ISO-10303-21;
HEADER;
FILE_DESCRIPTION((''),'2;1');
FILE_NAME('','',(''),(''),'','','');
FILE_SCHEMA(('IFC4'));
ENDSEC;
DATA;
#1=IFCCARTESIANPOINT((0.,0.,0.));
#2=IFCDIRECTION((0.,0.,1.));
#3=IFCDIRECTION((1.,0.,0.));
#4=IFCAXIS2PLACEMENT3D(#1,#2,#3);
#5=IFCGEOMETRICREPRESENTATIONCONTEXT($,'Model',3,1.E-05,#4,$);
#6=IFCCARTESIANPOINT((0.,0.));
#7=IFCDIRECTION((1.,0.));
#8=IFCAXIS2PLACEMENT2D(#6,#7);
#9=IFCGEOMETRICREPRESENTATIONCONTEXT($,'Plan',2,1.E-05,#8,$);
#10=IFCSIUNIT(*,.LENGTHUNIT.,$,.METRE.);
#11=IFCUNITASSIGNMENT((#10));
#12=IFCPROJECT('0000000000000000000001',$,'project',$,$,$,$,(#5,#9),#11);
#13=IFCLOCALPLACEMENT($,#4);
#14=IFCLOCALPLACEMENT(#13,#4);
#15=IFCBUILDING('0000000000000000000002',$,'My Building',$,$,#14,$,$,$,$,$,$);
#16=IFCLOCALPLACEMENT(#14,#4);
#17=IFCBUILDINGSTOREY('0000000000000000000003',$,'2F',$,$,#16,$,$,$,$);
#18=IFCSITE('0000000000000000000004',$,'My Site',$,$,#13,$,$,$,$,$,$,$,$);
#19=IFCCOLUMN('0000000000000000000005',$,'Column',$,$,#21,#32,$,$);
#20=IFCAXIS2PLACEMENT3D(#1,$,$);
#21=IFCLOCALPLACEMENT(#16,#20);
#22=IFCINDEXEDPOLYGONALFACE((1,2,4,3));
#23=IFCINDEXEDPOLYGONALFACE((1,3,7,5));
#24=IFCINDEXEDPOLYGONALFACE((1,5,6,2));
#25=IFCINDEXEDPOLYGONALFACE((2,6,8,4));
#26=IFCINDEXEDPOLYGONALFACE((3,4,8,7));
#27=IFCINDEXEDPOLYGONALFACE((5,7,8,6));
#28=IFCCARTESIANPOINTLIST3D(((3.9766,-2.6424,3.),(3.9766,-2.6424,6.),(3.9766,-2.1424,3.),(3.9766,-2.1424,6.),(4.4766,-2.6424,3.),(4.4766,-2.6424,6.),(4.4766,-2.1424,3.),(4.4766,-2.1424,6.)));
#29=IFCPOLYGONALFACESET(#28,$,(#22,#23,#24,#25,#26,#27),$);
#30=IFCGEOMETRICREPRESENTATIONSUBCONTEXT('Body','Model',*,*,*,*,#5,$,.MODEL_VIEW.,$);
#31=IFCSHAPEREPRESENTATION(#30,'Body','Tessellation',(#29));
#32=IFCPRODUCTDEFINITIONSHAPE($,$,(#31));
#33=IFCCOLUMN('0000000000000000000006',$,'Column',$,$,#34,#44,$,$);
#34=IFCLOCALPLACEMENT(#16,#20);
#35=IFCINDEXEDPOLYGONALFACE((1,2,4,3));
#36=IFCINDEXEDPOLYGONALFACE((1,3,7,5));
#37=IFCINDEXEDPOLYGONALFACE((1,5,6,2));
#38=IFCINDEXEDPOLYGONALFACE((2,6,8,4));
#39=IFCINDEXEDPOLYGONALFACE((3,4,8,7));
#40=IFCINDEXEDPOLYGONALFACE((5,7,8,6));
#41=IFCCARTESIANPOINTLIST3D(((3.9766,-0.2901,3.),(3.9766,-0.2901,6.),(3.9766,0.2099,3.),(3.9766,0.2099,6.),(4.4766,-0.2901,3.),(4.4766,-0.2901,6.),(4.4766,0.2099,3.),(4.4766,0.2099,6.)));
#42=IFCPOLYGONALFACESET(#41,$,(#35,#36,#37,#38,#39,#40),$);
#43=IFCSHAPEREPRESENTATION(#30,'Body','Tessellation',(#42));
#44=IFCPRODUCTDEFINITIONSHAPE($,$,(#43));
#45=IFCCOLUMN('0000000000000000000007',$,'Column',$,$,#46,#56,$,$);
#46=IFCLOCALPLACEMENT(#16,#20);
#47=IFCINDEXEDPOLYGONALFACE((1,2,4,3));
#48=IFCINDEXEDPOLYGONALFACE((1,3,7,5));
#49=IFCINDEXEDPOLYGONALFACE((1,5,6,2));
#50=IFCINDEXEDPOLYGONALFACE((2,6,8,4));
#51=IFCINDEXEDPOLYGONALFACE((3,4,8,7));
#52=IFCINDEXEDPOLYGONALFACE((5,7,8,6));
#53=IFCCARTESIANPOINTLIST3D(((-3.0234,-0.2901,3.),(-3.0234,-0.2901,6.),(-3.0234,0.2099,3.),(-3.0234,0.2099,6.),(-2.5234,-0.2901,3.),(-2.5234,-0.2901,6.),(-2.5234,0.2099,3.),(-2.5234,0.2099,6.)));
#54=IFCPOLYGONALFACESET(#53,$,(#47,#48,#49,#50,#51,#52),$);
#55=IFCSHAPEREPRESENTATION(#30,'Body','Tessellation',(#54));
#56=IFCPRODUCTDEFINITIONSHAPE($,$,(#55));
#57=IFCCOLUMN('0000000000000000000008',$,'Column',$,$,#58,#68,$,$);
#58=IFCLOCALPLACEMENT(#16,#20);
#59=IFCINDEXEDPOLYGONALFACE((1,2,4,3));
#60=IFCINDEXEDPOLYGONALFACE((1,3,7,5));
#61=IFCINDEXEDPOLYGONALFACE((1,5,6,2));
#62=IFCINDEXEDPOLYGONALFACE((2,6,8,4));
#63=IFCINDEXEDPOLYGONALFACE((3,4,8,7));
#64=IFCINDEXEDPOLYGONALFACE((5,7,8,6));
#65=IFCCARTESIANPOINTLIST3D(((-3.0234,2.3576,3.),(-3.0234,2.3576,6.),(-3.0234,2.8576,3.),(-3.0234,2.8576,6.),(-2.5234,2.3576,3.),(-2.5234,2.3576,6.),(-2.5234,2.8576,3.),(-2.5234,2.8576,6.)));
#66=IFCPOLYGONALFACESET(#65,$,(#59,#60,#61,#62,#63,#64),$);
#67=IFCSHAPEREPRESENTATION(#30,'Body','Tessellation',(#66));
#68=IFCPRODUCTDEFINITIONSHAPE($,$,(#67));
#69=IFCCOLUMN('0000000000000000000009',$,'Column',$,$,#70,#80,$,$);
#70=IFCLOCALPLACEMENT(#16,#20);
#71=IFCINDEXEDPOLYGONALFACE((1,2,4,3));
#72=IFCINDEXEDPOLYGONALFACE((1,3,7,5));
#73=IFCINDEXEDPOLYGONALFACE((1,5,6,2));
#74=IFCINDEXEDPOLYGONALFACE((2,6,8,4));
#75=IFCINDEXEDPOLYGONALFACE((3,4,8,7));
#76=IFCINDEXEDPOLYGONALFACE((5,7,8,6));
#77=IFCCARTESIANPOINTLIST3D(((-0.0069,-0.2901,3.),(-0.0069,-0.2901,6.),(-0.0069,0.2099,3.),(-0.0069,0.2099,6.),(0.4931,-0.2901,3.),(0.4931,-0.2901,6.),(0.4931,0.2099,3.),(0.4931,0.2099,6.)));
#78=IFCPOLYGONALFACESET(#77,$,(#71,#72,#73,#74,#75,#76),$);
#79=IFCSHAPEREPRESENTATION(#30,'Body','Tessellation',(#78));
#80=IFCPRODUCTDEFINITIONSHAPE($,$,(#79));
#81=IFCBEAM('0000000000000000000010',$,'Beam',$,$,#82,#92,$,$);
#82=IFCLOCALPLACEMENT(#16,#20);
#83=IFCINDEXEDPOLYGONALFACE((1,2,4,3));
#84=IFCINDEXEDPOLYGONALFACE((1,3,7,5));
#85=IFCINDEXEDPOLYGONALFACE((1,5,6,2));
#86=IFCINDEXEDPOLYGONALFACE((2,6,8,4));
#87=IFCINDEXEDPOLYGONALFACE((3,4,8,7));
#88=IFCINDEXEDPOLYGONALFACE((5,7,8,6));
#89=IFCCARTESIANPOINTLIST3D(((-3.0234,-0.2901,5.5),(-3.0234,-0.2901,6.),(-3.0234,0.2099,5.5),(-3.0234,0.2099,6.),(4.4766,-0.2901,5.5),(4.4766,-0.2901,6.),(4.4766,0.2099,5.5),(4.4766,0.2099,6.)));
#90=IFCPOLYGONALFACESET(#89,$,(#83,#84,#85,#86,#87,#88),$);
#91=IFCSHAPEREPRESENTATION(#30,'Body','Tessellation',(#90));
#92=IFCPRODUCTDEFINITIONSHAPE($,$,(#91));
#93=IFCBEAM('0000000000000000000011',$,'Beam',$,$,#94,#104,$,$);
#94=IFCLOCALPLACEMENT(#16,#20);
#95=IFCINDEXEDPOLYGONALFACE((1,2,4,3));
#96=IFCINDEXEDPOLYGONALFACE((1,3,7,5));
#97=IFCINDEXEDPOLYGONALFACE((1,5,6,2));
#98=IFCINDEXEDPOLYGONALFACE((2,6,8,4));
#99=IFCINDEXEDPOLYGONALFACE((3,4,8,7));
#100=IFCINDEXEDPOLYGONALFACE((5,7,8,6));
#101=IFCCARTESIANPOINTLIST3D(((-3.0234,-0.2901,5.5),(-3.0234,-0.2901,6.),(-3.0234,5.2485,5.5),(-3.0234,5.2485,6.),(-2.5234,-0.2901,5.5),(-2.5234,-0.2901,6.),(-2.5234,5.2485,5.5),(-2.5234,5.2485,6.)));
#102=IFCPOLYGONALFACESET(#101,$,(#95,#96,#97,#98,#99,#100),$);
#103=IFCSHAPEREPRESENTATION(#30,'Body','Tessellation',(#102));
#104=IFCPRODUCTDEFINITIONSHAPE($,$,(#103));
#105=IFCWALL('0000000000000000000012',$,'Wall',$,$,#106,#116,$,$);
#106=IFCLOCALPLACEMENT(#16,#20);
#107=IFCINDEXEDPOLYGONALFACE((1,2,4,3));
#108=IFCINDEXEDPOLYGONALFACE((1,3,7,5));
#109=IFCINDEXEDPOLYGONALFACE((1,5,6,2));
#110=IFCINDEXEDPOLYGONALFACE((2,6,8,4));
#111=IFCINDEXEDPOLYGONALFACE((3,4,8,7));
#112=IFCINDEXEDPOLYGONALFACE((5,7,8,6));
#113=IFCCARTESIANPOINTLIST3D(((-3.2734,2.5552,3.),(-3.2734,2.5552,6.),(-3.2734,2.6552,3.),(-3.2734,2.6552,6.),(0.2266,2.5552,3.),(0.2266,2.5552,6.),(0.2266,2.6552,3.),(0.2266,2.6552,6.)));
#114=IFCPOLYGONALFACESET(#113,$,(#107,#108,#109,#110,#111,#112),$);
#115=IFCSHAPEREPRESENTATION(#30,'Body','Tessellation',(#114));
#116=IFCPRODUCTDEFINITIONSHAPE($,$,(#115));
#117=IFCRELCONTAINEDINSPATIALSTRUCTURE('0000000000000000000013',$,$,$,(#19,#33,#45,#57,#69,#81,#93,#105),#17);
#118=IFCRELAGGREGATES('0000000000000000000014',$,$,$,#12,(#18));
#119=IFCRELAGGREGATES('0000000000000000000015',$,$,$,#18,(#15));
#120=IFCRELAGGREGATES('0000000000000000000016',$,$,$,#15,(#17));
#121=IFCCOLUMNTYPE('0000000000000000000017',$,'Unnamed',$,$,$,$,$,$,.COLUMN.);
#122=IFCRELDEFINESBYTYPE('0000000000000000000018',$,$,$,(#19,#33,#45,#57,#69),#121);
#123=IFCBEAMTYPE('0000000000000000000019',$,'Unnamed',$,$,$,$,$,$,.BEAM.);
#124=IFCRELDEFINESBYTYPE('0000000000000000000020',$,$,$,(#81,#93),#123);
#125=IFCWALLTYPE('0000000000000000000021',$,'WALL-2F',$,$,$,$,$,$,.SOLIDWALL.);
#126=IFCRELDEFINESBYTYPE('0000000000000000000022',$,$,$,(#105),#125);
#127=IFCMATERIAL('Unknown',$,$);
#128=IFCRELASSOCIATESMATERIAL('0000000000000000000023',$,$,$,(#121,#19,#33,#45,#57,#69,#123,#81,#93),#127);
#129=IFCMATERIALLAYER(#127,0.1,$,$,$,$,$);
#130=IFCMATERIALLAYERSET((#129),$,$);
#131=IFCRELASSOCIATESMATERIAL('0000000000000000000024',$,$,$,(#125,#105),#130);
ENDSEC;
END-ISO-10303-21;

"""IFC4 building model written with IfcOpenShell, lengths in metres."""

from ifc_helpers import new_model, si_unit, frame, origin_with_axes, origin_2d_with_axis, place, context, subcontext, project, spatial, line, indexed_curve, rectangle, outline, extrude, material, layer, layer_set, layer_usage, material_profile, profile_set, profile_usage, type_object, element, save


model = new_model("IFC4")

# Units and contexts
model_context = context("Model", 3, precision=1e-05, world=origin_with_axes())
plan_context = context("Plan", 2, precision=1e-05, world=origin_2d_with_axis())
body_context_1 = subcontext(model_context, "Body", "Model", "MODEL_VIEW")
ifc_project = project(units=[si_unit("LENGTHUNIT", "METRE")], contexts=[model_context, plan_context])

# Site, building, storey
site_placement = place(None, origin_with_axes())
site = spatial("IfcSite", under=ifc_project, at=site_placement, Name="My Site")
building_placement = place(site_placement, origin_with_axes())
building = spatial("IfcBuilding", under=site, at=building_placement, Name="My Building")
storey_placement = place(building_placement, origin_with_axes())
storey = spatial("IfcBuildingStorey", under=building, at=storey_placement, Name="2F")

# Columns
ifc_material = material(Name="Unknown")
ifc_material_profile_1 = material_profile(ifc_material, rectangle(XDim=0.5, YDim=0.5))
ifc_profile_set_1 = profile_set([ifc_material_profile_1])
ifc_profile_usage_1 = profile_usage(ifc_profile_set_1, cardinal=7)
column_type = type_object("IfcColumnType", Name="Unnamed", PredefinedType="COLUMN", material=ifc_profile_set_1)
column_1_placement = place(storey_placement, frame((4.4766, -2.1424, 3.0), z_axis=(0.0, 0.0, 1.0), x_axis=(1.0, 0.0, 0.0)))
element("IfcColumn", 1, at=column_1_placement, inside=storey, type_object=column_type, material=ifc_profile_usage_1, Name="Column", context=body_context_1, shape_type="SweptSolid", body=[
    extrude(rectangle(XDim=0.5, YDim=0.5), frame((-0.25, -0.25, 0.0), z_axis=(0.0, 0.0, 1.0), x_axis=(1.0, 0.0, 0.0)), (0.0, 0.0, 1.0), 3.0),
])
ifc_profile_usage_2 = profile_usage(ifc_profile_set_1, cardinal=7)
column_2_placement = place(storey_placement, frame((4.4766, 0.2099, 3.0), z_axis=(0.0, 0.0, 1.0), x_axis=(1.0, 0.0, 0.0)))
element("IfcColumn", 2, at=column_2_placement, inside=storey, type_object=column_type, material=ifc_profile_usage_2, Name="Column", context=body_context_1, shape_type="SweptSolid", body=[
    extrude(rectangle(XDim=0.5, YDim=0.5), frame((-0.25, -0.25, 0.0), z_axis=(0.0, 0.0, 1.0), x_axis=(1.0, 0.0, 0.0)), (0.0, 0.0, 1.0), 3.0),
])
ifc_profile_usage_3 = profile_usage(ifc_profile_set_1, cardinal=7)
column_3_placement = place(storey_placement, frame((-2.5234, 0.2099, 3.0), z_axis=(0.0, 0.0, 1.0), x_axis=(1.0, 0.0, 0.0)))
element("IfcColumn", 3, at=column_3_placement, inside=storey, type_object=column_type, material=ifc_profile_usage_3, Name="Column", context=body_context_1, shape_type="SweptSolid", body=[
    extrude(rectangle(XDim=0.5, YDim=0.5), frame((-0.25, -0.25, 0.0), z_axis=(0.0, 0.0, 1.0), x_axis=(1.0, 0.0, 0.0)), (0.0, 0.0, 1.0), 3.0),
])
ifc_profile_usage_4 = profile_usage(ifc_profile_set_1, cardinal=7)
column_4_placement = place(storey_placement, frame((-2.5234, 2.8576, 3.0), z_axis=(0.0, 0.0, 1.0), x_axis=(1.0, 0.0, 0.0)))
element("IfcColumn", 4, at=column_4_placement, inside=storey, type_object=column_type, material=ifc_profile_usage_4, Name="Column", context=body_context_1, shape_type="SweptSolid", body=[
    extrude(rectangle(XDim=0.5, YDim=0.5), frame((-0.25, -0.25, 0.0), z_axis=(0.0, 0.0, 1.0), x_axis=(1.0, 0.0, 0.0)), (0.0, 0.0, 1.0), 3.0),
])
ifc_profile_usage_5 = profile_usage(ifc_profile_set_1, cardinal=7)
column_5_placement = place(storey_placement, frame((0.4931, 0.2099, 3.0), z_axis=(0.0, 0.0, 1.0), x_axis=(1.0, 0.0, 0.0)))
element("IfcColumn", 5, at=column_5_placement, inside=storey, type_object=column_type, material=ifc_profile_usage_5, Name="Column", context=body_context_1, shape_type="SweptSolid", body=[
    extrude(rectangle(XDim=0.5, YDim=0.5), frame((-0.25, -0.25, 0.0), z_axis=(0.0, 0.0, 1.0), x_axis=(1.0, 0.0, 0.0)), (0.0, 0.0, 1.0), 3.0),
])

# Beams
ifc_material_profile_2 = material_profile(ifc_material, rectangle(XDim=0.5, YDim=0.5))
ifc_profile_set_2 = profile_set([ifc_material_profile_2])
ifc_profile_usage_6 = profile_usage(ifc_profile_set_2, cardinal=7)
beam_type = type_object("IfcBeamType", Name="Unnamed", PredefinedType="BEAM", material=ifc_profile_set_2)
beam_1_placement = place(storey_placement, frame((-3.0234, 0.2099, 6.0), z_axis=(1.0, 0.0, 0.0), x_axis=(0.0, 1.0, 0.0)))
element("IfcBeam", 6, at=beam_1_placement, inside=storey, type_object=beam_type, material=ifc_profile_usage_6, Name="Beam", context=body_context_1, shape_type="SweptSolid", body=[
    extrude(rectangle(XDim=0.5, YDim=0.5), frame((-0.25, -0.25, 0.0), z_axis=(0.0, 0.0, 1.0), x_axis=(1.0, 0.0, 0.0)), (0.0, 0.0, 1.0), 7.5),
])
ifc_profile_usage_7 = profile_usage(ifc_profile_set_2, cardinal=7)
beam_2_placement = place(storey_placement, frame((-3.0234, -0.2901, 6.0), z_axis=(0.0, 1.0, 0.0), x_axis=(-1.0, 0.0, 0.0)))
element("IfcBeam", 7, at=beam_2_placement, inside=storey, type_object=beam_type, material=ifc_profile_usage_7, Name="Beam", context=body_context_1, shape_type="SweptSolid", body=[
    extrude(rectangle(XDim=0.5, YDim=0.5), frame((-0.25, -0.25, 0.0), z_axis=(0.0, 0.0, 1.0), x_axis=(1.0, 0.0, 0.0)), (0.0, 0.0, 1.0), 5.5386),
])

# Wall
ifc_layer_1 = layer(ifc_material, 0.1)
ifc_layer_set_1 = layer_set([ifc_layer_1])
ifc_layer_usage_1 = layer_usage(ifc_layer_set_1, "AXIS2", "POSITIVE", 0.0)
wall_type_1 = type_object("IfcWallType", Name="WALL-2F", PredefinedType="SOLIDWALL", material=ifc_layer_set_1)
wall_1_placement = place(storey_placement, frame((-3.2734, 2.5552, 3.0), z_axis=(0.0, 0.0, 1.0), x_axis=(1.0, 0.0, 0.0)))
element("IfcWall", 8, at=wall_1_placement, inside=storey, type_object=wall_type_1, material=ifc_layer_usage_1, Name="Wall", context=body_context_1, shape_type="SweptSolid", body=[
    extrude(outline(indexed_curve([(0.0, 0.0), (0.0, 0.1), (3.5, 0.1), (3.5, 0.0)], segments=[line(1, 2, 3, 4, 1)])), origin_with_axes(), (0.0, 0.0, 1.0), 3.0),
])

save(model, "model.ifc")
